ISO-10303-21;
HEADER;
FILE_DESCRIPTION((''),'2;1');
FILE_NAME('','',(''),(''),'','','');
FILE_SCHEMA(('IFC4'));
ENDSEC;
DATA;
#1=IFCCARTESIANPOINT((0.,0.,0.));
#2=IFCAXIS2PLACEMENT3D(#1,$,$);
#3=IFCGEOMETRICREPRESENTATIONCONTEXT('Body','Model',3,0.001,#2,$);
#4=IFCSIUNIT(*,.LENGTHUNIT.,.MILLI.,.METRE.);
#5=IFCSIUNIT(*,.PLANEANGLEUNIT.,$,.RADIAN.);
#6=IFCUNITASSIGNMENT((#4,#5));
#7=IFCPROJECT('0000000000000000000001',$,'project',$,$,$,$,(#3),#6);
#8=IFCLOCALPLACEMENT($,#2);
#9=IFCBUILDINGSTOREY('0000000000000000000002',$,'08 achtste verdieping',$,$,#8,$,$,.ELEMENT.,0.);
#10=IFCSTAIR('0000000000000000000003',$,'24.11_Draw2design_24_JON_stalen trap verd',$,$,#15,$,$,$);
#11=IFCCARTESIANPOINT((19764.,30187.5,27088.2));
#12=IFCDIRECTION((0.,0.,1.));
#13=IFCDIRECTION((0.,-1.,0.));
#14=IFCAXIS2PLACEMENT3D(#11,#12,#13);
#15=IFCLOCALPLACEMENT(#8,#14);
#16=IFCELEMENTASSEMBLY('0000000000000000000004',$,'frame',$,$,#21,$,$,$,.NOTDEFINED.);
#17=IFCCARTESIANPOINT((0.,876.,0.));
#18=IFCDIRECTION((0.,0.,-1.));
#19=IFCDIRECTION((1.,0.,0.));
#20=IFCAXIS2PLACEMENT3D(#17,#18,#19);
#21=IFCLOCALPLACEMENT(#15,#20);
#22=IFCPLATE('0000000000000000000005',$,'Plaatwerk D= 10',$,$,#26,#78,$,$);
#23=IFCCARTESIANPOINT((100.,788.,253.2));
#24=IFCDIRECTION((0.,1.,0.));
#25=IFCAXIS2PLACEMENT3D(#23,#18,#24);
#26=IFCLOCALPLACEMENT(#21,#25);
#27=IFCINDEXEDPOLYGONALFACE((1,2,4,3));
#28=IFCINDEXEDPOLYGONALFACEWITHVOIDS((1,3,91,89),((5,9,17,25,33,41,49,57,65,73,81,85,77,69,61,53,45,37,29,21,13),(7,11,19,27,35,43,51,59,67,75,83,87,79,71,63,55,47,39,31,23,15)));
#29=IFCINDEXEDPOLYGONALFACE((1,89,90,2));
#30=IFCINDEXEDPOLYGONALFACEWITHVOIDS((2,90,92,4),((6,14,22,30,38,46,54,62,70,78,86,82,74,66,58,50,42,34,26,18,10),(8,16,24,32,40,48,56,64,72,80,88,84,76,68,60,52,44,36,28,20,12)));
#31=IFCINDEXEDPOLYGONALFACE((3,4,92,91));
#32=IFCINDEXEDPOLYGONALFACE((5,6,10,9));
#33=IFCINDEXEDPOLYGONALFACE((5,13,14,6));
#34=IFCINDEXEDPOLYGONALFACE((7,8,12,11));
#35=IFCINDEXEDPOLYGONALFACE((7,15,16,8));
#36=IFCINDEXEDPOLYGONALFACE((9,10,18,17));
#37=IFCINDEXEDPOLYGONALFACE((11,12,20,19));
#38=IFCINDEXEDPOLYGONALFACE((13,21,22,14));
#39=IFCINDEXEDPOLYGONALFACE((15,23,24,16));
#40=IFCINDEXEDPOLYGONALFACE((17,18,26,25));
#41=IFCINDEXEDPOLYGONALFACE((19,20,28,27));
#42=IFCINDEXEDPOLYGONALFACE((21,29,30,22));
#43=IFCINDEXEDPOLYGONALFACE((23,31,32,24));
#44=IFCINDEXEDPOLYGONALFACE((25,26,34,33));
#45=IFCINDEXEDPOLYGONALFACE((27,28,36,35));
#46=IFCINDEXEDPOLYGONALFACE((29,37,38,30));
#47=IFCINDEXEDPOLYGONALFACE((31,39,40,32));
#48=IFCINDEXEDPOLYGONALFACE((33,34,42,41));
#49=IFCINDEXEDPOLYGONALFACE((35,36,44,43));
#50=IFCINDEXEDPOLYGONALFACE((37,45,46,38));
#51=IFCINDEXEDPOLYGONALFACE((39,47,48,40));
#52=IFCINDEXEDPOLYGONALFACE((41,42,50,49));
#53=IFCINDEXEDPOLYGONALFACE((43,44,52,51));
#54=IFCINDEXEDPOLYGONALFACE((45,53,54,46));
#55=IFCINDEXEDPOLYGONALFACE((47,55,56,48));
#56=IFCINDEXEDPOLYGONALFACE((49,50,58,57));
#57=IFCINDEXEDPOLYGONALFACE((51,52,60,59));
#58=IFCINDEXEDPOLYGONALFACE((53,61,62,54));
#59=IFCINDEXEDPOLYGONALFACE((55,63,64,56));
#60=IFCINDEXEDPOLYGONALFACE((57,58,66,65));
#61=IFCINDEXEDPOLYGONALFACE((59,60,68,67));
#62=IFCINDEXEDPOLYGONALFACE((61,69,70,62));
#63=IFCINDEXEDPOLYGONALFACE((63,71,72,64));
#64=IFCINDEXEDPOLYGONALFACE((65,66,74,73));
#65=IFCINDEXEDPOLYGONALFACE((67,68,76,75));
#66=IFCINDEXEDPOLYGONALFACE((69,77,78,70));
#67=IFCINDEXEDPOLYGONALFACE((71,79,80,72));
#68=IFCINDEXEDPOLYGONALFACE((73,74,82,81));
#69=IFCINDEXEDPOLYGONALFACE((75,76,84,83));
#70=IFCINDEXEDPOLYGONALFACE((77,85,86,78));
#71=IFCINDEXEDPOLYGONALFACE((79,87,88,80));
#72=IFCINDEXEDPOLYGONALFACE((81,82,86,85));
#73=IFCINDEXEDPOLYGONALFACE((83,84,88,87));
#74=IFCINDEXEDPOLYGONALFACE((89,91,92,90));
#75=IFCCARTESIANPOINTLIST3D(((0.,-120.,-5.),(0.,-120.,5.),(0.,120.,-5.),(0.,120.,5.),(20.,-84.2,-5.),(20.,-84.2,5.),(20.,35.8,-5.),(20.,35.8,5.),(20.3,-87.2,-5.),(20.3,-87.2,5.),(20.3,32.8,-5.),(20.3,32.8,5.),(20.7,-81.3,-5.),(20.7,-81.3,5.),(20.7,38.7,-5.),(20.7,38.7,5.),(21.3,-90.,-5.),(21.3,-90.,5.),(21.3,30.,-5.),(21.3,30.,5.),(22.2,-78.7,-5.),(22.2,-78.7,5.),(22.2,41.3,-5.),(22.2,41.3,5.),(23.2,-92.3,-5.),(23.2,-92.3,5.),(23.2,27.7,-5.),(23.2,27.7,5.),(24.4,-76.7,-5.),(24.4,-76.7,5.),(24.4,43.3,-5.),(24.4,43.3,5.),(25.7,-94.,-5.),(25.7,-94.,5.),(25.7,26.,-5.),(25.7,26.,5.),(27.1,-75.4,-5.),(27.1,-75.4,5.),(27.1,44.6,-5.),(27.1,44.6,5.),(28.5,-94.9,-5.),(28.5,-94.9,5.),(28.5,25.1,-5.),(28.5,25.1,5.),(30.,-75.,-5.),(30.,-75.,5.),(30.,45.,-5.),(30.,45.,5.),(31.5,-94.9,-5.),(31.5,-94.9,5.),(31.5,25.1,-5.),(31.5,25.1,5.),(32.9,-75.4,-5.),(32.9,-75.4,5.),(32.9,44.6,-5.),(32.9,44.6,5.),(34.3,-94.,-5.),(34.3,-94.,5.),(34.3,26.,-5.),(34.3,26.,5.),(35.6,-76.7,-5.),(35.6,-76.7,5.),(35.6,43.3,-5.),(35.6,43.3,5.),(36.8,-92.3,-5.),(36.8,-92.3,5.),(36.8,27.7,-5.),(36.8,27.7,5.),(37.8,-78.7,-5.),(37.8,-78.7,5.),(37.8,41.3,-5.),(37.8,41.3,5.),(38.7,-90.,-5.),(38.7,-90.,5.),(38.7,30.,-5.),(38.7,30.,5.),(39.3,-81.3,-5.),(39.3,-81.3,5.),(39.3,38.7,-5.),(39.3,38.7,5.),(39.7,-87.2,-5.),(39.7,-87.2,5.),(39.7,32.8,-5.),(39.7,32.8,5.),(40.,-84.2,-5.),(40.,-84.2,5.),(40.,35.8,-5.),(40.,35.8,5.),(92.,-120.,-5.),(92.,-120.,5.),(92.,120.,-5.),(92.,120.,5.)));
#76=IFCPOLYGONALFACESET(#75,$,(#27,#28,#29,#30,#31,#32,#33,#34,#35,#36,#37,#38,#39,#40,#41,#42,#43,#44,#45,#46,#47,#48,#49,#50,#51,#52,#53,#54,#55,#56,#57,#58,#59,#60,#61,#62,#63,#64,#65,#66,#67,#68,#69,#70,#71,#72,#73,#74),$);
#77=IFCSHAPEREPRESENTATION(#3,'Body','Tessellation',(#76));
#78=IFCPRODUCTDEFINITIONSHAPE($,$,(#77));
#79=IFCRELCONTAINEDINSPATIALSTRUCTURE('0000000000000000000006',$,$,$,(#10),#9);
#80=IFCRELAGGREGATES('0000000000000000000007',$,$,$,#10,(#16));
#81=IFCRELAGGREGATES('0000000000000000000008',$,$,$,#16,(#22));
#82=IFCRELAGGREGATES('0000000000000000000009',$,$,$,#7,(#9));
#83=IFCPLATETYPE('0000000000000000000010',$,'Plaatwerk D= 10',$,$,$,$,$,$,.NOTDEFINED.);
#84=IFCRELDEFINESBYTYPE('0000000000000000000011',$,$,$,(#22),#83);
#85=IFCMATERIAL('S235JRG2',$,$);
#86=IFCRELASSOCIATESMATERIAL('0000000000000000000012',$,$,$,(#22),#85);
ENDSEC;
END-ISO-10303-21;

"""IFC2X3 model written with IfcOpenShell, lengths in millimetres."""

from ifc_helpers import new_model, si_unit, frame, origin, origin_2d, place, context, project, spatial, rectangle, circle, extrude, source, transform, mapped, material, type_object, element, aggregate, save


model = new_model("IFC2X3")

# Units and contexts
model_context = context("Model", 3, precision=0.001, world=origin(), identifier="Body")
ifc_project = project(units=[si_unit("LENGTHUNIT", "METRE", prefix="MILLI"), si_unit("PLANEANGLEUNIT", "RADIAN")], contexts=[model_context])

# Storey
storey_placement = place(None, origin())
storey = spatial("IfcBuildingStorey", under=ifc_project, at=storey_placement, Name="08 achtste verdieping", CompositionType="ELEMENT", Elevation=0.0)

# Shared definitions
ifc_material_1 = material(Name="S235JRG2")

# Stair
stair_placement = place(storey_placement, frame((19764.0, 30187.5, 27088.2), z_axis=(0.0, 0.0, 1.0), x_axis=(0.0, -1.0, 0.0)))
stair = element("IfcStair", 1, at=stair_placement, inside=storey, Name="24.11_Draw2design_24_JON_stalen trap verd")

# Element assembly
assembly_placement = place(stair_placement, frame((0.0, 876.0, 0.0), z_axis=(0.0, 0.0, -1.0), x_axis=(1.0, 0.0, 0.0)))
assembly = element("IfcElementAssembly", 2, at=assembly_placement, Name="frame", PredefinedType="NOTDEFINED")
aggregate(stair, [assembly])

# Plate, openings
plate_type = type_object("IfcPlateType", Name="Plaatwerk D= 10")
shared_shape_1 = source(origin(), model_context, "Body", "SweptSolid", [
    extrude(rectangle(XDim=92.0, YDim=240.0, at=origin_2d()), frame((46.0, 0.0, -5.0)), (0.0, 0.0, 1.0), 10.0),
])
plate_1_placement = place(assembly_placement, frame((100.0, 788.0, 253.2), z_axis=(0.0, 0.0, -1.0), x_axis=(0.0, 1.0, 0.0)))
plate_1 = element("IfcPlate", 3, at=plate_1_placement, type_object=plate_type, material=ifc_material_1, Name="Plaatwerk D= 10", context=model_context, shape_type="MappedRepresentation", body=[
    mapped(shared_shape_1, transform((0.0, 0.0, 0.0), scale=1.0)),
])
opening_1_placement = place(plate_1_placement, frame((30.0, -85.0, 5.0), z_axis=(0.0, 0.0, -1.0), x_axis=(0.0, 1.0, 0.0)))
element("IfcOpeningElement", 4, at=opening_1_placement, cuts=plate_1, ObjectType="Opening", context=model_context, shape_type="SweptSolid", body=[
    extrude(circle(Radius=10.0, at=origin_2d()), origin(), (0.0, 0.0, 1.0), 10.0),
])
opening_2_placement = place(plate_1_placement, frame((30.0, 35.0, 5.0), z_axis=(0.0, 0.0, -1.0), x_axis=(0.0, 1.0, 0.0)))
element("IfcOpeningElement", 5, at=opening_2_placement, cuts=plate_1, ObjectType="Opening", context=model_context, shape_type="SweptSolid", body=[
    extrude(circle(Radius=10.0, at=origin_2d()), origin(), (0.0, 0.0, 1.0), 10.0),
])
aggregate(assembly, [plate_1])

save(model, "model.ifc")
